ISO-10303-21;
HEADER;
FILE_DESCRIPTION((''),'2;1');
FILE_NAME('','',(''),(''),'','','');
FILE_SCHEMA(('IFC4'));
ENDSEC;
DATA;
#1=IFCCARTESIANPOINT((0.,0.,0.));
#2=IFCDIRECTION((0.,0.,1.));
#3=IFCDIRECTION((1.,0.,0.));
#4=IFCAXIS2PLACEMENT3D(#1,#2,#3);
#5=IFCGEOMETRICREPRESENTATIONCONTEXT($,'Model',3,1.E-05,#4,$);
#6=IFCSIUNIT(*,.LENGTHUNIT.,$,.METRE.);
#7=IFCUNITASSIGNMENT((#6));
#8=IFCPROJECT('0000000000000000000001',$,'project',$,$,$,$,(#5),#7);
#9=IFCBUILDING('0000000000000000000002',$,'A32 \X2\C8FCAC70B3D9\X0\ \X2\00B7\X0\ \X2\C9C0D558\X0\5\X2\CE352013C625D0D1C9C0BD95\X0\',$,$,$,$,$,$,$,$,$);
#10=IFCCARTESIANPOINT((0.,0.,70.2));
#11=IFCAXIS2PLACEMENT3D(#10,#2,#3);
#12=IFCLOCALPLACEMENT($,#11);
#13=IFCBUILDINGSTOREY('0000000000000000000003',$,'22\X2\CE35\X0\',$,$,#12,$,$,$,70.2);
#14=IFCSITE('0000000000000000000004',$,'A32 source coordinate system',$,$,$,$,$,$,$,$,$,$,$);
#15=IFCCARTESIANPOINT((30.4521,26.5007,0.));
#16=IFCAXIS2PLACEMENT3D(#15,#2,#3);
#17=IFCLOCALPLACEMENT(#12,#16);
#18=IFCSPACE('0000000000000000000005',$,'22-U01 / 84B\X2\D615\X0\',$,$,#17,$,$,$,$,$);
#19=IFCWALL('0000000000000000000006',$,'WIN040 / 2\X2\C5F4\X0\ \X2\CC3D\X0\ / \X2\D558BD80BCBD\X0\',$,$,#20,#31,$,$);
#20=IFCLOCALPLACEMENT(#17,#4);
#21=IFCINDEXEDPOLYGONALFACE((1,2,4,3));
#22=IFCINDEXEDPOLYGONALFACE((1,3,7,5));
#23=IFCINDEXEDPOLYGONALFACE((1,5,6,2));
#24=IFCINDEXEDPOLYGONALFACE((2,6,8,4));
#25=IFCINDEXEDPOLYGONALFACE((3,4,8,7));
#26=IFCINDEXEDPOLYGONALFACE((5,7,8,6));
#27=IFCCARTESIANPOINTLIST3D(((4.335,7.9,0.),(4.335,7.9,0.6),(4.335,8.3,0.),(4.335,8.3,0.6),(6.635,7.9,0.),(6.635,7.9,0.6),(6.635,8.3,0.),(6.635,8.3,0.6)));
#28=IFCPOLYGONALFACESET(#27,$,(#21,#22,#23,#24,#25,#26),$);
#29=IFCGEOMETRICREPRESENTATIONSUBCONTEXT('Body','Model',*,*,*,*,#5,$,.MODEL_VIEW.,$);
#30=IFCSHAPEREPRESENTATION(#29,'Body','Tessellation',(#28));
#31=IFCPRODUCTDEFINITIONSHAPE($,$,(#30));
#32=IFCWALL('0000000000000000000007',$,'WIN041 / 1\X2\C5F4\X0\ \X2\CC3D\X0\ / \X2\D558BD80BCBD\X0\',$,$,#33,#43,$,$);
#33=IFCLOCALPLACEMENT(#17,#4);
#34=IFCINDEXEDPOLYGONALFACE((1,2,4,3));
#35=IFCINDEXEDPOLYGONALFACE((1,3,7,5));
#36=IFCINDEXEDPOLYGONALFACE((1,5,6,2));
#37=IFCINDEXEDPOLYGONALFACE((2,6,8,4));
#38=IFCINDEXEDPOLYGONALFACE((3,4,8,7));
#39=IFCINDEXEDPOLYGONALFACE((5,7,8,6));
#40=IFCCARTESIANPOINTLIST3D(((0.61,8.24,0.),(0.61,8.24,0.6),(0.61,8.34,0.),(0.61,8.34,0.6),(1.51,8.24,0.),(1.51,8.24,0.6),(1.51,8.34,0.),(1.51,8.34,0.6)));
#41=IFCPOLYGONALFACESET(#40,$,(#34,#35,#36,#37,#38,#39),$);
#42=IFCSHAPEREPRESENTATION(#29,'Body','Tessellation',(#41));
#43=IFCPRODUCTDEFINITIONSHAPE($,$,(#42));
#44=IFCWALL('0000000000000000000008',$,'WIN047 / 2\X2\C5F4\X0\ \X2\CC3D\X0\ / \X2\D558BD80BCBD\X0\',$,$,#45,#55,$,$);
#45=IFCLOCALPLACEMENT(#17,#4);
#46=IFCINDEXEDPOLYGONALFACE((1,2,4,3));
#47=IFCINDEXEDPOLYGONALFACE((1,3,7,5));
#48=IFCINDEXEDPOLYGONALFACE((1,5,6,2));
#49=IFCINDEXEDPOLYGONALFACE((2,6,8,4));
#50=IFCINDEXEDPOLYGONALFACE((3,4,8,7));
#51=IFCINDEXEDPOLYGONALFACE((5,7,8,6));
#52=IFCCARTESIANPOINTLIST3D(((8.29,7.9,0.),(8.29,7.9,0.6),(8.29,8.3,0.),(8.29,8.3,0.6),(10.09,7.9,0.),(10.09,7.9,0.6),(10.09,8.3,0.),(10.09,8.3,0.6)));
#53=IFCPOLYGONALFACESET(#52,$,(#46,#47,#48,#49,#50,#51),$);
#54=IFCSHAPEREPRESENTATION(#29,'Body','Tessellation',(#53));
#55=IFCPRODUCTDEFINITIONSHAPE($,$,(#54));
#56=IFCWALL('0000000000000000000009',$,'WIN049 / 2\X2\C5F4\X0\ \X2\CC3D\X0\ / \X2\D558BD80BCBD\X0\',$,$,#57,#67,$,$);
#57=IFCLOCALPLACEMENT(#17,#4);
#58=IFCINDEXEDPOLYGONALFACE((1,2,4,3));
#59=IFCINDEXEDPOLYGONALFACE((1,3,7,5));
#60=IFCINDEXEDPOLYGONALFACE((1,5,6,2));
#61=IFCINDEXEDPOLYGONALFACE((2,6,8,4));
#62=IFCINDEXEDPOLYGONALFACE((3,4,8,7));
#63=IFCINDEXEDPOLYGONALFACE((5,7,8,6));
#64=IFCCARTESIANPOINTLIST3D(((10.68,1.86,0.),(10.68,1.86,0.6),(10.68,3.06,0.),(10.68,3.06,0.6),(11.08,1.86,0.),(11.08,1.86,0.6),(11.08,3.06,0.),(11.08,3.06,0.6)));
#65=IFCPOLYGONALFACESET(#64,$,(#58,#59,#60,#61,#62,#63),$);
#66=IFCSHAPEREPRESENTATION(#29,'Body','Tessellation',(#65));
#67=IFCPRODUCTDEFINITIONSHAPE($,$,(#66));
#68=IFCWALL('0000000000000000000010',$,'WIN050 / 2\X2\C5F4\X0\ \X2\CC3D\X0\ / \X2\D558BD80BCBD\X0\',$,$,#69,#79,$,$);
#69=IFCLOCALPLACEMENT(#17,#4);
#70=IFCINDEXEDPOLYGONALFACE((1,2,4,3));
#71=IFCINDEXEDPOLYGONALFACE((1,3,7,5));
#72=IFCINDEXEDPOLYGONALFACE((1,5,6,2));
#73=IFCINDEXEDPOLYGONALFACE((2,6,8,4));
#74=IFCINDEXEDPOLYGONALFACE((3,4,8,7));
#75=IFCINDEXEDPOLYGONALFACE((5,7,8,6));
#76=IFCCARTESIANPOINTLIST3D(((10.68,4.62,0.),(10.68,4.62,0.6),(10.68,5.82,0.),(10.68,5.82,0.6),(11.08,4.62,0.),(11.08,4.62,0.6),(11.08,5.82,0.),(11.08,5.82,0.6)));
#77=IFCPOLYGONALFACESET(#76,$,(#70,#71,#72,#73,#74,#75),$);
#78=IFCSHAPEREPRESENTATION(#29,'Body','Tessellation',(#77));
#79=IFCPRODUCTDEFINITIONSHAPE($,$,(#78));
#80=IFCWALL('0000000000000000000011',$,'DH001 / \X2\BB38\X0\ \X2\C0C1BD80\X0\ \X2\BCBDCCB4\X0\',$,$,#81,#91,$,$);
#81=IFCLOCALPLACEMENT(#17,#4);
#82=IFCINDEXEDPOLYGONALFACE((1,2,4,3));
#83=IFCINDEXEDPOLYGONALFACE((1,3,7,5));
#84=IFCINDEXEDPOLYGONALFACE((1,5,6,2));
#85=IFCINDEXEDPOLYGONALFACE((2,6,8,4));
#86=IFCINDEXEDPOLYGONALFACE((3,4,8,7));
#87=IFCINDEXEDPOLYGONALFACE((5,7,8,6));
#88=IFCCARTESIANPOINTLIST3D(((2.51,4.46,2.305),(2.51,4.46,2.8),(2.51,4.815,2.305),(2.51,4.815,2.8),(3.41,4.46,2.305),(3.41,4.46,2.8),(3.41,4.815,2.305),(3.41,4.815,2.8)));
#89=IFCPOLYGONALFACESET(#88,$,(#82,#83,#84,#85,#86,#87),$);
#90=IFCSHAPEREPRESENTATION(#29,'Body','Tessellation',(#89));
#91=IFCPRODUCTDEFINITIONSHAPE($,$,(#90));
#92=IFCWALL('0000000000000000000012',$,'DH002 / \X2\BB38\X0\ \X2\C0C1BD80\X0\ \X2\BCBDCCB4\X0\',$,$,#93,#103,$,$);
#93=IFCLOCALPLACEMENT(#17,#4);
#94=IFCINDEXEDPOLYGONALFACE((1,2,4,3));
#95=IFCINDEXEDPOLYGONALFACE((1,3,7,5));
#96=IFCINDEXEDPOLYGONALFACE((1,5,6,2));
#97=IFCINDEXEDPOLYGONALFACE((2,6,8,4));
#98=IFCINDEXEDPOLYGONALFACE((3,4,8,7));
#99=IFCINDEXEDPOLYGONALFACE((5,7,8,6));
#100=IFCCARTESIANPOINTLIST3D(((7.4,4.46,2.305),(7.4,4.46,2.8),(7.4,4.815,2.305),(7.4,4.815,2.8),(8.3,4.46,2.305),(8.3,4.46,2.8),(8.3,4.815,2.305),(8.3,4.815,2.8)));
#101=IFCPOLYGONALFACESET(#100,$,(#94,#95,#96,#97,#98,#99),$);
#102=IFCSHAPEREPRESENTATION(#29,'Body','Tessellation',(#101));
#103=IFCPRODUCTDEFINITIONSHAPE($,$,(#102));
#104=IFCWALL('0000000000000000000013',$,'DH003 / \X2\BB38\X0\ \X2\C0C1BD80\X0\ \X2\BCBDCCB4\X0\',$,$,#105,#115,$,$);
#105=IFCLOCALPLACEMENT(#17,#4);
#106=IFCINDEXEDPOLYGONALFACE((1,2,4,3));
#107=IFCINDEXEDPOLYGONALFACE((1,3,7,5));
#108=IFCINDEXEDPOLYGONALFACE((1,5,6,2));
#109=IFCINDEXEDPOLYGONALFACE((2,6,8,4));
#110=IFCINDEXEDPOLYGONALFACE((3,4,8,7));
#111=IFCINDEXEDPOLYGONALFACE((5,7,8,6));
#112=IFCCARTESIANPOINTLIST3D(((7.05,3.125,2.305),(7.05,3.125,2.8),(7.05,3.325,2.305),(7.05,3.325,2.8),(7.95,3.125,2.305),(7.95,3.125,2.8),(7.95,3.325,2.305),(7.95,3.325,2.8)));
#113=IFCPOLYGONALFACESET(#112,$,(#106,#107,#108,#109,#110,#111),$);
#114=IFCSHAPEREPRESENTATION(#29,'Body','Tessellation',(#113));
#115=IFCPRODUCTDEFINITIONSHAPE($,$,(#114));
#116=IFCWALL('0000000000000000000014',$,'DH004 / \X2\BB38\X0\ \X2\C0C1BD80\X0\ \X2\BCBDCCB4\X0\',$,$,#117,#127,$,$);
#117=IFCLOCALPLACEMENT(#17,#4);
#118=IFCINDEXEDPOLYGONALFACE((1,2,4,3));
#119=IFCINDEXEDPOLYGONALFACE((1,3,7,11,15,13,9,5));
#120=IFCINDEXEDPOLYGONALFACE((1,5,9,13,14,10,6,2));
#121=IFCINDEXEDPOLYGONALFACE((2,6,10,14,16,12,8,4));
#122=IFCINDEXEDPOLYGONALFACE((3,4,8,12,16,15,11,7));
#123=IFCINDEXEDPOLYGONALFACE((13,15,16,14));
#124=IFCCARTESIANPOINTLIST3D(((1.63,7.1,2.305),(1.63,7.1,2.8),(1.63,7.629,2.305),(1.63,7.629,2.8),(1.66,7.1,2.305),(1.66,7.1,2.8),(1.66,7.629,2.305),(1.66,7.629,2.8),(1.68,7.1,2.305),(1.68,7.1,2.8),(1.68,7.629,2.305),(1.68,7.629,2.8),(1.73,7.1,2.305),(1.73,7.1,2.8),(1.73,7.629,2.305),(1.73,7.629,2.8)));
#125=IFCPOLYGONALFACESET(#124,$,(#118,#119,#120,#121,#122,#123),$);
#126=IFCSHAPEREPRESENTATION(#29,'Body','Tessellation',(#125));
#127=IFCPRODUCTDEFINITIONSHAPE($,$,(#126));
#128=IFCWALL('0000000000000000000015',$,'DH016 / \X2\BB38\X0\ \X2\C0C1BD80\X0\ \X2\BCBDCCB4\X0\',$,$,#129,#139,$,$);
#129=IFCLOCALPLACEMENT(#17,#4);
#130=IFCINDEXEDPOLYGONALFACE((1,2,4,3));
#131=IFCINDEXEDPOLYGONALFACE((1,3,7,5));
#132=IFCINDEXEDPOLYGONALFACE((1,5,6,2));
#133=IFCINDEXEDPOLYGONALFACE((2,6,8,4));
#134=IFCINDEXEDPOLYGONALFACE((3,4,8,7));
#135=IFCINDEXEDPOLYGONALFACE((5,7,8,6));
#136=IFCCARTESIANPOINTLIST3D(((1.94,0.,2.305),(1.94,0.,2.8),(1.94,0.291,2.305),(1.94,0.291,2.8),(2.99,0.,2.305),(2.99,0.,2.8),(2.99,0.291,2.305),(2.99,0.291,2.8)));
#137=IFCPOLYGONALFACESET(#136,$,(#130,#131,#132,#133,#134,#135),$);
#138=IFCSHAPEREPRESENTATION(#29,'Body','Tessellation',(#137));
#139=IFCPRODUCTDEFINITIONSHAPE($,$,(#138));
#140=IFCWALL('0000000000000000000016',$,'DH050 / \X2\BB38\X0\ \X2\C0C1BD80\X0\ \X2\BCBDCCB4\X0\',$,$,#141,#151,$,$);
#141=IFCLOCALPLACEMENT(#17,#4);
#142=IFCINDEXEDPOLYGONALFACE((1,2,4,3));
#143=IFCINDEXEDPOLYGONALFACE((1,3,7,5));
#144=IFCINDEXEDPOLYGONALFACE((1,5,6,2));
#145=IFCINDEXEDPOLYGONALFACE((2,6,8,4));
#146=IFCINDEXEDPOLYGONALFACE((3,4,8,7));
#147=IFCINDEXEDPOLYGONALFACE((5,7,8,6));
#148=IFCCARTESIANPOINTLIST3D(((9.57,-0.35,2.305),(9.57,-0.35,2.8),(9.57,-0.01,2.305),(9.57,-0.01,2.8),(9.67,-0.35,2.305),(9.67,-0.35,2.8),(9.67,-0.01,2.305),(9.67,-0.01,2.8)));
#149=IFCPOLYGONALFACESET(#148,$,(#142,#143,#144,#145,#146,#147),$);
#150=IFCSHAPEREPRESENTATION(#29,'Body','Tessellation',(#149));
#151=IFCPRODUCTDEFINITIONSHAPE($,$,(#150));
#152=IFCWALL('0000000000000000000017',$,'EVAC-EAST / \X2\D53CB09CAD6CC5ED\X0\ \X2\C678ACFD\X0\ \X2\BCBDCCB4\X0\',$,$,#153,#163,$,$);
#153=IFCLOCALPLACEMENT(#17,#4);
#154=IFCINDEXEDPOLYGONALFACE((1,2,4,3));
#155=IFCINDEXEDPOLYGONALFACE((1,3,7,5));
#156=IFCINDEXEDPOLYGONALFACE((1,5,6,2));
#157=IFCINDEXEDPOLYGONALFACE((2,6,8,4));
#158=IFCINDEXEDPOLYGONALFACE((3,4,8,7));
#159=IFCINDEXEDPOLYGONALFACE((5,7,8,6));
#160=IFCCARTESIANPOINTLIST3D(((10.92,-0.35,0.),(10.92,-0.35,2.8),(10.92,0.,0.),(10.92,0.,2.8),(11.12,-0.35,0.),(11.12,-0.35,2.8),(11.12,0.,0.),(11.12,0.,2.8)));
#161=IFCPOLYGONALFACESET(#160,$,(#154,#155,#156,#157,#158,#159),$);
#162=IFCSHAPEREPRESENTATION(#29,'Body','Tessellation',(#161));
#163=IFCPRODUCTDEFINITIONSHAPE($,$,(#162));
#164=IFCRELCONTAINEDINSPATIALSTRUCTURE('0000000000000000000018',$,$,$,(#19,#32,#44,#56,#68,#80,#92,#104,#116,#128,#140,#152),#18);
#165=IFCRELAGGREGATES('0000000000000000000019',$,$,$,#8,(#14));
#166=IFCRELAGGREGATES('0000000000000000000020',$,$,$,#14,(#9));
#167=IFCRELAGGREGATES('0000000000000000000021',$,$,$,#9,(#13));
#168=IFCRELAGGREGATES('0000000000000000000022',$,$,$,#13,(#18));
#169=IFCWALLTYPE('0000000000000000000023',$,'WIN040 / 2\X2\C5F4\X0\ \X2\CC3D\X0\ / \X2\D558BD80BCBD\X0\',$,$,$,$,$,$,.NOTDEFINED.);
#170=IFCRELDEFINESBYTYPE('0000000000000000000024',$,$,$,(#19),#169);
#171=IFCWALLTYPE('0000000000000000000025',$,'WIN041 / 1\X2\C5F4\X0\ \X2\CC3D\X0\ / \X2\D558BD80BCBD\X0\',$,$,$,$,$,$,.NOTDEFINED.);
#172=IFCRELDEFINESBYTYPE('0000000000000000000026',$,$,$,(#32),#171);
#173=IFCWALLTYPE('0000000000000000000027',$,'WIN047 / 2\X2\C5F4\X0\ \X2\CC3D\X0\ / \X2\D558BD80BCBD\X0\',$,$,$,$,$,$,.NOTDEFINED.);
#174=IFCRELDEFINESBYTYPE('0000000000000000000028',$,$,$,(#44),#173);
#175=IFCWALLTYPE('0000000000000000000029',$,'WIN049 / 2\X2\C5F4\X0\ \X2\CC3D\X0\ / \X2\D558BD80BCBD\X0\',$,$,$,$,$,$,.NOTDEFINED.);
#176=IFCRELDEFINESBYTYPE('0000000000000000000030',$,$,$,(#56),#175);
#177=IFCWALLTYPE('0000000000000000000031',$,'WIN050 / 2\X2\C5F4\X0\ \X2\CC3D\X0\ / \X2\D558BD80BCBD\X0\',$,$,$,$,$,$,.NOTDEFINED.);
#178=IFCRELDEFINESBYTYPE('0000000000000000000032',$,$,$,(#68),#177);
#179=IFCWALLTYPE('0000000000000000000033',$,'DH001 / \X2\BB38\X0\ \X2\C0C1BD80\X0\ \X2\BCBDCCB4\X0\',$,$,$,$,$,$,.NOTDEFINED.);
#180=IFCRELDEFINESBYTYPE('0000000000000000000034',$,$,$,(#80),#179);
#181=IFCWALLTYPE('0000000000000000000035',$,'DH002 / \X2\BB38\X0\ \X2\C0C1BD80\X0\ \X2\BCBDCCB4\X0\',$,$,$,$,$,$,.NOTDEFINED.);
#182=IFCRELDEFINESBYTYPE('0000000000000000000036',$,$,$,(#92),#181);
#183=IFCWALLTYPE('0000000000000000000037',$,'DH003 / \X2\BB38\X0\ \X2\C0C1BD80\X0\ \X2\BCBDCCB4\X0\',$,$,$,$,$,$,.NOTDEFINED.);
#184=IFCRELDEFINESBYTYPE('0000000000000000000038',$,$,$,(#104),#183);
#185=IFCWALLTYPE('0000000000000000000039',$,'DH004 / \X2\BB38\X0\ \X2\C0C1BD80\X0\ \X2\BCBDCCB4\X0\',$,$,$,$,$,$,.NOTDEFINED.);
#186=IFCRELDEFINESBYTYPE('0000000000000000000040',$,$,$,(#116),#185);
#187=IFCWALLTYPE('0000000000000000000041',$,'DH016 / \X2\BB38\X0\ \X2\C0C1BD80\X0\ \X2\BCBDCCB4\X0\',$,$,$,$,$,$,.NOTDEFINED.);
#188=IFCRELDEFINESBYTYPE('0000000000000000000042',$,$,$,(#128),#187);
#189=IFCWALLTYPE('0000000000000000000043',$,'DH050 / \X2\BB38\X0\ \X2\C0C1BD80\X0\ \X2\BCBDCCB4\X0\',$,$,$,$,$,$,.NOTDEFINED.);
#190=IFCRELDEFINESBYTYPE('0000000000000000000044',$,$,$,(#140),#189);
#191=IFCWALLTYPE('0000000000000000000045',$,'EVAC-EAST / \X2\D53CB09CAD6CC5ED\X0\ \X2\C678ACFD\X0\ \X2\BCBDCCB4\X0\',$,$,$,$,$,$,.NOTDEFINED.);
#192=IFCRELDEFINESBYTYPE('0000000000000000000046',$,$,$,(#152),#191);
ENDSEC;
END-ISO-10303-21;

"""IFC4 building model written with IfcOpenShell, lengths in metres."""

from ifc_helpers import new_model, si_unit, frame, origin, origin_with_axes, place, context, subcontext, project, spatial, polyline, outline, extrude, source, transform, mapped, type_object, type_shapes, element, save


model = new_model("IFC4")

# Units and contexts
model_context = context("Model", 3, precision=1e-05, world=origin_with_axes())
body_context = subcontext(model_context, "Body", "Model", "MODEL_VIEW")
ifc_project = project(units=[si_unit("LENGTHUNIT", "METRE")], contexts=[model_context])

# Site, building, storey, space
site = spatial("IfcSite", under=ifc_project, Name="A32 source coordinate system")
building = spatial("IfcBuilding", under=site, Name="A32 주거동 · 지하5층–옥탑지붕")
storey_placement = place(None, frame((0.0, 0.0, 70.2), z_axis=(0.0, 0.0, 1.0), x_axis=(1.0, 0.0, 0.0)))
storey = spatial("IfcBuildingStorey", under=building, at=storey_placement, Name="22층", Elevation=70.2)
space_placement = place(storey_placement, frame((30.4521, 26.5007, 0.0), z_axis=(0.0, 0.0, 1.0), x_axis=(1.0, 0.0, 0.0)))
space = spatial("IfcSpace", under=storey, at=space_placement, Name="22-U01 / 84B형")

# Walls
wall_type_1 = type_object("IfcWallType", Name="WIN040 / 2열 창 / 하부벽", PredefinedType="NOTDEFINED")
shared_shape_1 = source(origin(), body_context, "Body", "SweptSolid", [
    extrude(outline(polyline([(4.335, 8.3), (6.635, 8.3), (6.635, 7.9), (4.335, 7.9), (4.335, 8.3)])), origin(), (0.0, 0.0, 1.0), 0.6),
])
type_shapes(wall_type_1, [shared_shape_1])
wall_1_placement = place(space_placement, origin_with_axes())
element("IfcWall", 1, at=wall_1_placement, inside=space, type_object=wall_type_1, Name="WIN040 / 2열 창 / 하부벽", context=body_context, shape_type="MappedRepresentation", body=[
    mapped(shared_shape_1, transform((0.0, 0.0, 0.0), scale=1.0)),
])
wall_type_2 = type_object("IfcWallType", Name="WIN041 / 1열 창 / 하부벽", PredefinedType="NOTDEFINED")
shared_shape_2 = source(origin(), body_context, "Body", "SweptSolid", [
    extrude(outline(polyline([(0.61, 8.34), (1.51, 8.34), (1.51, 8.24), (0.61, 8.24), (0.61, 8.34)])), origin(), (0.0, 0.0, 1.0), 0.6),
])
type_shapes(wall_type_2, [shared_shape_2])
wall_2_placement = place(space_placement, origin_with_axes())
element("IfcWall", 2, at=wall_2_placement, inside=space, type_object=wall_type_2, Name="WIN041 / 1열 창 / 하부벽", context=body_context, shape_type="MappedRepresentation", body=[
    mapped(shared_shape_2, transform((0.0, 0.0, 0.0), scale=1.0)),
])
wall_type_3 = type_object("IfcWallType", Name="WIN047 / 2열 창 / 하부벽", PredefinedType="NOTDEFINED")
shared_shape_3 = source(origin(), body_context, "Body", "SweptSolid", [
    extrude(outline(polyline([(8.29, 8.3), (10.09, 8.3), (10.09, 7.9), (8.29, 7.9), (8.29, 8.3)])), origin(), (0.0, 0.0, 1.0), 0.6),
])
type_shapes(wall_type_3, [shared_shape_3])
wall_3_placement = place(space_placement, origin_with_axes())
element("IfcWall", 3, at=wall_3_placement, inside=space, type_object=wall_type_3, Name="WIN047 / 2열 창 / 하부벽", context=body_context, shape_type="MappedRepresentation", body=[
    mapped(shared_shape_3, transform((0.0, 0.0, 0.0), scale=1.0)),
])
wall_type_4 = type_object("IfcWallType", Name="WIN049 / 2열 창 / 하부벽", PredefinedType="NOTDEFINED")
shared_shape_4 = source(origin(), body_context, "Body", "SweptSolid", [
    extrude(outline(polyline([(10.68, 3.06), (11.08, 3.06), (11.08, 1.86), (10.68, 1.86), (10.68, 3.06)])), origin(), (0.0, 0.0, 1.0), 0.6),
])
type_shapes(wall_type_4, [shared_shape_4])
wall_4_placement = place(space_placement, origin_with_axes())
element("IfcWall", 4, at=wall_4_placement, inside=space, type_object=wall_type_4, Name="WIN049 / 2열 창 / 하부벽", context=body_context, shape_type="MappedRepresentation", body=[
    mapped(shared_shape_4, transform((0.0, 0.0, 0.0), scale=1.0)),
])
wall_type_5 = type_object("IfcWallType", Name="WIN050 / 2열 창 / 하부벽", PredefinedType="NOTDEFINED")
shared_shape_5 = source(origin(), body_context, "Body", "SweptSolid", [
    extrude(outline(polyline([(10.68, 5.82), (11.08, 5.82), (11.08, 4.62), (10.68, 4.62), (10.68, 5.82)])), origin(), (0.0, 0.0, 1.0), 0.6),
])
type_shapes(wall_type_5, [shared_shape_5])
wall_5_placement = place(space_placement, origin_with_axes())
element("IfcWall", 5, at=wall_5_placement, inside=space, type_object=wall_type_5, Name="WIN050 / 2열 창 / 하부벽", context=body_context, shape_type="MappedRepresentation", body=[
    mapped(shared_shape_5, transform((0.0, 0.0, 0.0), scale=1.0)),
])
wall_type_6 = type_object("IfcWallType", Name="DH001 / 문 상부 벽체", PredefinedType="NOTDEFINED")
shared_shape_6 = source(origin(), body_context, "Body", "SweptSolid", [
    extrude(outline(polyline([(3.41, 4.815), (3.41, 4.46), (2.51, 4.46), (2.51, 4.815), (3.41, 4.815)])), frame((0.0, 0.0, 2.305)), (0.0, 0.0, 1.0), 0.495),
])
type_shapes(wall_type_6, [shared_shape_6])
wall_6_placement = place(space_placement, origin_with_axes())
element("IfcWall", 6, at=wall_6_placement, inside=space, type_object=wall_type_6, Name="DH001 / 문 상부 벽체", context=body_context, shape_type="MappedRepresentation", body=[
    mapped(shared_shape_6, transform((0.0, 0.0, 0.0), scale=1.0)),
])
wall_type_7 = type_object("IfcWallType", Name="DH002 / 문 상부 벽체", PredefinedType="NOTDEFINED")
shared_shape_7 = source(origin(), body_context, "Body", "SweptSolid", [
    extrude(outline(polyline([(8.3, 4.815), (8.3, 4.46), (7.4, 4.46), (7.4, 4.815), (8.3, 4.815)])), frame((0.0, 0.0, 2.305)), (0.0, 0.0, 1.0), 0.495),
])
type_shapes(wall_type_7, [shared_shape_7])
wall_7_placement = place(space_placement, origin_with_axes())
element("IfcWall", 7, at=wall_7_placement, inside=space, type_object=wall_type_7, Name="DH002 / 문 상부 벽체", context=body_context, shape_type="MappedRepresentation", body=[
    mapped(shared_shape_7, transform((0.0, 0.0, 0.0), scale=1.0)),
])
wall_type_8 = type_object("IfcWallType", Name="DH003 / 문 상부 벽체", PredefinedType="NOTDEFINED")
shared_shape_8 = source(origin(), body_context, "Body", "SweptSolid", [
    extrude(outline(polyline([(7.95, 3.325), (7.95, 3.125), (7.05, 3.125), (7.05, 3.325), (7.95, 3.325)])), frame((0.0, 0.0, 2.305)), (0.0, 0.0, 1.0), 0.495),
])
type_shapes(wall_type_8, [shared_shape_8])
wall_8_placement = place(space_placement, origin_with_axes())
element("IfcWall", 8, at=wall_8_placement, inside=space, type_object=wall_type_8, Name="DH003 / 문 상부 벽체", context=body_context, shape_type="MappedRepresentation", body=[
    mapped(shared_shape_8, transform((0.0, 0.0, 0.0), scale=1.0)),
])
wall_type_9 = type_object("IfcWallType", Name="DH004 / 문 상부 벽체", PredefinedType="NOTDEFINED")
shared_shape_9 = source(origin(), body_context, "Body", "SweptSolid", [
    extrude(outline(polyline([(1.66, 7.1), (1.63, 7.1), (1.63, 7.629), (1.66, 7.629), (1.68, 7.629), (1.73, 7.629), (1.73, 7.1), (1.68, 7.1), (1.66, 7.1)])), frame((0.0, 0.0, 2.305)), (0.0, 0.0, 1.0), 0.495),
])
type_shapes(wall_type_9, [shared_shape_9])
wall_9_placement = place(space_placement, origin_with_axes())
element("IfcWall", 9, at=wall_9_placement, inside=space, type_object=wall_type_9, Name="DH004 / 문 상부 벽체", context=body_context, shape_type="MappedRepresentation", body=[
    mapped(shared_shape_9, transform((0.0, 0.0, 0.0), scale=1.0)),
])
wall_type_10 = type_object("IfcWallType", Name="DH016 / 문 상부 벽체", PredefinedType="NOTDEFINED")
shared_shape_10 = source(origin(), body_context, "Body", "SweptSolid", [
    extrude(outline(polyline([(2.99, 0.291), (2.99, 0.0), (1.94, 0.0), (1.94, 0.291), (2.99, 0.291)])), frame((0.0, 0.0, 2.305)), (0.0, 0.0, 1.0), 0.495),
])
type_shapes(wall_type_10, [shared_shape_10])
wall_10_placement = place(space_placement, origin_with_axes())
element("IfcWall", 10, at=wall_10_placement, inside=space, type_object=wall_type_10, Name="DH016 / 문 상부 벽체", context=body_context, shape_type="MappedRepresentation", body=[
    mapped(shared_shape_10, transform((0.0, 0.0, 0.0), scale=1.0)),
])
wall_type_11 = type_object("IfcWallType", Name="DH050 / 문 상부 벽체", PredefinedType="NOTDEFINED")
shared_shape_11 = source(origin(), body_context, "Body", "SweptSolid", [
    extrude(outline(polyline([(9.67, -0.01), (9.67, -0.35), (9.57, -0.35), (9.57, -0.01), (9.67, -0.01)])), frame((0.0, 0.0, 2.305)), (0.0, 0.0, 1.0), 0.495),
])
type_shapes(wall_type_11, [shared_shape_11])
wall_11_placement = place(space_placement, origin_with_axes())
element("IfcWall", 11, at=wall_11_placement, inside=space, type_object=wall_type_11, Name="DH050 / 문 상부 벽체", context=body_context, shape_type="MappedRepresentation", body=[
    mapped(shared_shape_11, transform((0.0, 0.0, 0.0), scale=1.0)),
])
wall_type_12 = type_object("IfcWallType", Name="EVAC-EAST / 피난구역 외곽 벽체", PredefinedType="NOTDEFINED")
shared_shape_12 = source(origin(), body_context, "Body", "SweptSolid", [
    extrude(outline(polyline([(10.92, 0.0), (11.12, 0.0), (11.12, -0.35), (10.92, -0.35), (10.92, 0.0)])), origin(), (0.0, 0.0, 1.0), 2.8),
])
type_shapes(wall_type_12, [shared_shape_12])
wall_12_placement = place(space_placement, origin_with_axes())
element("IfcWall", 12, at=wall_12_placement, inside=space, type_object=wall_type_12, Name="EVAC-EAST / 피난구역 외곽 벽체", context=body_context, shape_type="MappedRepresentation", body=[
    mapped(shared_shape_12, transform((0.0, 0.0, 0.0), scale=1.0)),
])

save(model, "model.ifc")
